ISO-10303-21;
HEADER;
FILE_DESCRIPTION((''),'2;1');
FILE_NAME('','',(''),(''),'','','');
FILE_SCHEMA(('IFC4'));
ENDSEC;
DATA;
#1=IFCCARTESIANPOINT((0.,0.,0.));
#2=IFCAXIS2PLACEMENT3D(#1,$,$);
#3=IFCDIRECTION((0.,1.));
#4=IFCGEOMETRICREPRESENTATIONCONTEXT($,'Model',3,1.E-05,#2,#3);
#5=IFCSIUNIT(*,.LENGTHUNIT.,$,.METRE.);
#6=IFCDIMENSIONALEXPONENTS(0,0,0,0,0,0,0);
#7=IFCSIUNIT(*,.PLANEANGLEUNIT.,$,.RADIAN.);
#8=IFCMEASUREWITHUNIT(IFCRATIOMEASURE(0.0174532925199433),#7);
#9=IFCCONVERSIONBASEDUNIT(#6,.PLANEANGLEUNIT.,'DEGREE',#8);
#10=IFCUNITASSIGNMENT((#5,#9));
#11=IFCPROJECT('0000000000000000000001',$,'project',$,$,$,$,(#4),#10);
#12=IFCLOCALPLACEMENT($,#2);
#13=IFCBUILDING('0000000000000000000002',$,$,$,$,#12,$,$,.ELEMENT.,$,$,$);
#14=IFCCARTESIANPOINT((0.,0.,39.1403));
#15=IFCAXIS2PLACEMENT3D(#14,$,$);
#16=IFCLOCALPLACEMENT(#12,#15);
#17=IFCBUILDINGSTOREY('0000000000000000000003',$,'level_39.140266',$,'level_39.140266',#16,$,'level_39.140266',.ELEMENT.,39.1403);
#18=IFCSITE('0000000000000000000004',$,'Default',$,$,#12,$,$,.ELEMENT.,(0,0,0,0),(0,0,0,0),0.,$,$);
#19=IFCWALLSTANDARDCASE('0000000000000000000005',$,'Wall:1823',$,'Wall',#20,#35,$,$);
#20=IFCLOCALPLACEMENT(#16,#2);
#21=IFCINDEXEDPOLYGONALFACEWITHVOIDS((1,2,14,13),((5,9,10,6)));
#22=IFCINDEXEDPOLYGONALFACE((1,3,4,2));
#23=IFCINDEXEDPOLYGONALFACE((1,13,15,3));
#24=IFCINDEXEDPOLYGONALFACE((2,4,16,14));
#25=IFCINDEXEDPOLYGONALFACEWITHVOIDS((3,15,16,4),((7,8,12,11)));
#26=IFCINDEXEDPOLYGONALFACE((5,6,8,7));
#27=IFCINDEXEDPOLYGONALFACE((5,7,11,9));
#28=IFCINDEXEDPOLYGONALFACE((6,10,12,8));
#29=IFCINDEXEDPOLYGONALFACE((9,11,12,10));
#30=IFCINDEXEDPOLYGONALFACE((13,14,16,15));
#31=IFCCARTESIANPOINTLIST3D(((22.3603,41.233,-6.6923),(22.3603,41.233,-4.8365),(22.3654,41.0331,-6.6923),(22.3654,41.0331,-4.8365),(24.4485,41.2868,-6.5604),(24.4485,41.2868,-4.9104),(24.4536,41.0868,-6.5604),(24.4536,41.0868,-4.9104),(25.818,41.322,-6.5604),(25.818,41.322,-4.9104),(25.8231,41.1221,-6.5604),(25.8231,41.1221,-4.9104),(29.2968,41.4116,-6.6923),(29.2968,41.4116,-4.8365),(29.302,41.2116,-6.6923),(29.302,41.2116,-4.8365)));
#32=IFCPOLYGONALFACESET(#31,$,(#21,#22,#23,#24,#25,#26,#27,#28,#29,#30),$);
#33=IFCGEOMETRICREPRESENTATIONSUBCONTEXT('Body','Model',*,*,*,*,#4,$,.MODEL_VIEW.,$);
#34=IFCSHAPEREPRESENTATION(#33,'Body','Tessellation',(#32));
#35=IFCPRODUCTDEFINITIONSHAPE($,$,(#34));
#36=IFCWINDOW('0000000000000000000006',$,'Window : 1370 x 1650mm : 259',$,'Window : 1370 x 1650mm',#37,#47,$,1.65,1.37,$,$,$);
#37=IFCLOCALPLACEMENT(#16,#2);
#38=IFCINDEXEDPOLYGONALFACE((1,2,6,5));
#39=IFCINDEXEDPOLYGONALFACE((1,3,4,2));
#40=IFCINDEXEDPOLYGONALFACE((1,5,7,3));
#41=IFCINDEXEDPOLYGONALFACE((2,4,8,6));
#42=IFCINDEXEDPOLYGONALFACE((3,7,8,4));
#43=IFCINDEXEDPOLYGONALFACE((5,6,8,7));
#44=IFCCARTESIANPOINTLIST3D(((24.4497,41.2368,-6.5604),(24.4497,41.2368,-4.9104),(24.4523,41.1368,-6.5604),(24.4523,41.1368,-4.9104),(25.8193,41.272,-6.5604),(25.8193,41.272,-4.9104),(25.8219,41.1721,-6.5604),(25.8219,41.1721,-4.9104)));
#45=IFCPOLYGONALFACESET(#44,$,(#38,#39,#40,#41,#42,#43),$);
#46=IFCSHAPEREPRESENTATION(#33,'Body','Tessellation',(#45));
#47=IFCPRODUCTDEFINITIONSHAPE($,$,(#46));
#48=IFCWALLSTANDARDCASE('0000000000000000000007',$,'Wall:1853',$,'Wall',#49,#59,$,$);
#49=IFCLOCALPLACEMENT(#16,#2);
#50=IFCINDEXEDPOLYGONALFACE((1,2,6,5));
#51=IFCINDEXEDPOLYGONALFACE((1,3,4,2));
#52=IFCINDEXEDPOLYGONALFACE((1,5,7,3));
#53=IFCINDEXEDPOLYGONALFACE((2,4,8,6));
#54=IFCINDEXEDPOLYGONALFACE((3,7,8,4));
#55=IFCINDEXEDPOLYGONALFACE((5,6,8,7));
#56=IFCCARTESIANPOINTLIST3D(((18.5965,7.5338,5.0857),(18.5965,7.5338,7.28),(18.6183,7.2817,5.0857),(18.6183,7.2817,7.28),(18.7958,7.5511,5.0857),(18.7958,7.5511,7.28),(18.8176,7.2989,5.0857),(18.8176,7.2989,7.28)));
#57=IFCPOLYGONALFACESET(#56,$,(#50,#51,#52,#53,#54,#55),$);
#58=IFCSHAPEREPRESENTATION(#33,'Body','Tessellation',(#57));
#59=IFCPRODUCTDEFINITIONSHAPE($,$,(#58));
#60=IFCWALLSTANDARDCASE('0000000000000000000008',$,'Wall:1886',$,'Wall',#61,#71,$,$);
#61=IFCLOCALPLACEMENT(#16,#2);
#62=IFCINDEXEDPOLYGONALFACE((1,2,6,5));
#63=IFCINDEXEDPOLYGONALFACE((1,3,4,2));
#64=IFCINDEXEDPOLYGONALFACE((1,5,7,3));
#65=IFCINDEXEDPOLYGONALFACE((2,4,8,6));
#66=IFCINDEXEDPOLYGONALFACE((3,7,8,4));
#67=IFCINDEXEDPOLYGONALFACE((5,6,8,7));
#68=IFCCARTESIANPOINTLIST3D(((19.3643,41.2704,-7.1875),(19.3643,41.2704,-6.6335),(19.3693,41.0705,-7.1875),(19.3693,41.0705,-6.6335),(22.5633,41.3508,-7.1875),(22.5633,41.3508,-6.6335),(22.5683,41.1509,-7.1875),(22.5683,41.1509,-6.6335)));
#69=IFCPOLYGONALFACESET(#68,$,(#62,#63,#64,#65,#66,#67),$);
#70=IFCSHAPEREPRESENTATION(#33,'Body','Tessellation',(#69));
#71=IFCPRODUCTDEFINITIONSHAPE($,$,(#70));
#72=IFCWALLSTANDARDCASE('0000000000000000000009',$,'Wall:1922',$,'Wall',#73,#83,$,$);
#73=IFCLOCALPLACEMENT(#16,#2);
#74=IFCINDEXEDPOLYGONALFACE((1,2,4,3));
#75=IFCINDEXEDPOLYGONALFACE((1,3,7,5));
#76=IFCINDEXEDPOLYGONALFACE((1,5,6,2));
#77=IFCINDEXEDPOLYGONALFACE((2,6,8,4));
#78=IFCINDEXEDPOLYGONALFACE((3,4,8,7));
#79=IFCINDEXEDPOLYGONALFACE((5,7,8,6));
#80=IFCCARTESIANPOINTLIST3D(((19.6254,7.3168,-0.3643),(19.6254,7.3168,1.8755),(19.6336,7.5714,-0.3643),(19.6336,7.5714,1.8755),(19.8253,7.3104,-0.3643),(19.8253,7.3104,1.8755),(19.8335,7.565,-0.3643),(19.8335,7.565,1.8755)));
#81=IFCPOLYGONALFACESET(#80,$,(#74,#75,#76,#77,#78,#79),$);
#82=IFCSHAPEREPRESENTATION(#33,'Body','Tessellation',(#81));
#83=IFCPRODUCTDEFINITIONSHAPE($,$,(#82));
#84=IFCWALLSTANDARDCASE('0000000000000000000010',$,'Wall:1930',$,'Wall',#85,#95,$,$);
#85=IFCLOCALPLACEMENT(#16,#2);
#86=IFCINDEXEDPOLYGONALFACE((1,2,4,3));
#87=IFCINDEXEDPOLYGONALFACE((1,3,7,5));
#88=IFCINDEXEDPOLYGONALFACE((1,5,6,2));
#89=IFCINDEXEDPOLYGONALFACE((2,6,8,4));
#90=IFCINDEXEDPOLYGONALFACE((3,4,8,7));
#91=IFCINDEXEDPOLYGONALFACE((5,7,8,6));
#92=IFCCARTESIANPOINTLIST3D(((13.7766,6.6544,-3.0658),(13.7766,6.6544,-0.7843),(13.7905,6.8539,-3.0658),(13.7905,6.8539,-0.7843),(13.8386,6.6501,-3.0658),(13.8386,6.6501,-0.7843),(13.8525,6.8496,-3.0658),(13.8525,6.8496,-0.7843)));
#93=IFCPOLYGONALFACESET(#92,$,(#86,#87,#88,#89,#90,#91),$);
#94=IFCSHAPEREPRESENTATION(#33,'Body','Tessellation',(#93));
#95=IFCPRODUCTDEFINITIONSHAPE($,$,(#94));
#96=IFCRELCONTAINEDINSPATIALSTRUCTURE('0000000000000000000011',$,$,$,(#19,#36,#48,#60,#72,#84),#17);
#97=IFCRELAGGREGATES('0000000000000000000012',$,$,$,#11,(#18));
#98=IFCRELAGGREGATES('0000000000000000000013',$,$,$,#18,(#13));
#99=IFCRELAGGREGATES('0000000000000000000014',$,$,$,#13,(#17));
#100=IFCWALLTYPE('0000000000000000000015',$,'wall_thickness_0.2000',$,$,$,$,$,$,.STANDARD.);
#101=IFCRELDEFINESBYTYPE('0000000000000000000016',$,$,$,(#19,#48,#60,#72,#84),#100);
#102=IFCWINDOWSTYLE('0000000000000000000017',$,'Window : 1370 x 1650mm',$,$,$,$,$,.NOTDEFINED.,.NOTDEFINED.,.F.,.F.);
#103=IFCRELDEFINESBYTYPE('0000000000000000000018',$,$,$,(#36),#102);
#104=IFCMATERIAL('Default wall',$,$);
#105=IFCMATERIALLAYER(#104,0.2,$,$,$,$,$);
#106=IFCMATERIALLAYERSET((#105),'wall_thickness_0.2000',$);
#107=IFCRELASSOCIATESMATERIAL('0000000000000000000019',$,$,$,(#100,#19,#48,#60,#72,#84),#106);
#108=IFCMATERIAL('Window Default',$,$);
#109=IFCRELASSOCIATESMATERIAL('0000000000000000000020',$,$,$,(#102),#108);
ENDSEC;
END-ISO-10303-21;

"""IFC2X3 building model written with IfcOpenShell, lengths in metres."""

from ifc_helpers import new_model, entity, si_unit, converted_unit, direction, frame, frame_2d, origin, origin_2d_with_axis, place, context, subcontext, project, spatial, polyline, rectangle, outline, extrude, source, transform, mapped, material, layer, layer_set, layer_usage, type_object, type_shapes, element, fill, save


model = new_model("IFC2X3")

# Units and contexts
model_context = context("Model", 3, precision=1e-05, world=origin(), true_north=direction((0.0, 1.0)))
body_context = subcontext(model_context, "Body", "Model", "MODEL_VIEW")
ifc_project = project(units=[si_unit("LENGTHUNIT", "METRE"), converted_unit("PLANEANGLEUNIT", "DEGREE", entity("IfcRatioMeasure", 0.0174532925199433), si_unit("PLANEANGLEUNIT", "RADIAN"), dimensions=[0, 0, 0, 0, 0, 0, 0])], contexts=[model_context])

# Site, building, storey
placement_1 = place(None, origin())
site = spatial("IfcSite", under=ifc_project, at=placement_1, Name="Default", CompositionType="ELEMENT", RefLatitude=(0, 0, 0, 0), RefLongitude=(0, 0, 0, 0), RefElevation=0.0)
building = spatial("IfcBuilding", under=site, at=placement_1, CompositionType="ELEMENT")
storey_placement = place(placement_1, frame((0.0, 0.0, 39.1403)))
storey = spatial("IfcBuildingStorey", under=building, at=storey_placement, Name="level_39.140266", ObjectType="level_39.140266", LongName="level_39.140266", CompositionType="ELEMENT", Elevation=39.1403)

# Shared definitions
ifc_material_1 = material(Name="Default wall")
ifc_layer = layer(ifc_material_1, 0.2)
ifc_layer_set = layer_set([ifc_layer], Name="wall_thickness_0.2000")
ifc_layer_usage = layer_usage(ifc_layer_set, "AXIS2", "POSITIVE", -0.1)
wall_type = type_object("IfcWallType", Name="wall_thickness_0.2000", PredefinedType="STANDARD", material=ifc_layer_set)

# Shared definitions
ifc_material_2 = material(Name="Window Default")

# Wall, opening, window
placement_2 = place(placement_1, frame((0.0, 0.0, 32.448)))
wall_1_placement = place(placement_2, frame((22.3628, 41.133, 0.0), z_axis=(0.0, 0.0, 1.0), x_axis=(0.999669, 0.025736, 0.0)))
wall_1 = element("IfcWallStandardCase", 1, at=wall_1_placement, inside=storey, type_object=wall_type, material=ifc_layer_usage, Name="Wall:1823", ObjectType="Wall", context=body_context, shape_type="SweptSolid", body=[
    extrude(outline(polyline([(6.9389, -0.1), (6.9389, 0.1), (0.0, 0.1), (0.0, -0.1), (6.9389, -0.1)])), origin(), (0.0, 0.0, 1.0), 1.8558),
])
opening_1_placement = place(wall_1_placement, frame((2.0889, -0.1, 0.132)))
opening_1 = element("IfcOpeningElement", 2, at=opening_1_placement, cuts=wall_1, ObjectType="Opening", context=body_context, shape_type="SweptSolid", body=[
    extrude(rectangle(XDim=1.37, YDim=1.65, at=frame_2d((0.825, 0.685), x_axis=(0.0, 1.0))), frame((0.0, 0.0, 0.0), z_axis=(0.0, 1.0, 0.0), x_axis=(0.0, 0.0, 1.0)), (0.0, 0.0, 1.0), 0.2),
])
window_style_1 = type_object("IfcWindowStyle", Name="Window : 1370 x 1650mm", ConstructionType="NOTDEFINED", OperationType="NOTDEFINED", ParameterTakesPrecedence=False, Sizeable=False, material=ifc_material_2)
shared_shape_1 = source(origin(), body_context, "Body", "SweptSolid", [
    extrude(rectangle(XDim=0.1, YDim=1.37, at=origin_2d_with_axis()), frame((0.685, 0.1, 0.0), z_axis=(0.0, 0.0, 1.0), x_axis=(0.0, 1.0, 0.0)), (0.0, 0.0, 1.0), 1.65),
])
type_shapes(window_style_1, [shared_shape_1])
window_1_placement = place(opening_1_placement, origin())
window_1 = element("IfcWindow", 3, at=window_1_placement, inside=storey, type_object=window_style_1, Name="Window : 1370 x 1650mm : 259", ObjectType="Window : 1370 x 1650mm", OverallHeight=1.65, OverallWidth=1.37, context=body_context, shape_type="MappedRepresentation", body=[
    mapped(shared_shape_1, transform((0.0, 0.0, 0.0), scale=1.0)),
])
fill(opening_1, window_1)

# Walls
placement_3 = place(placement_1, frame((0.0, 0.0, 44.226)))
wall_2_placement = place(placement_3, frame((18.718, 7.2903, 0.0), z_axis=(0.0, 0.0, 1.0), x_axis=(-0.086239, 0.996275, 0.0)))
element("IfcWallStandardCase", 4, at=wall_2_placement, inside=storey, type_object=wall_type, material=ifc_layer_usage, Name="Wall:1853", ObjectType="Wall", context=body_context, shape_type="SweptSolid", body=[
    extrude(outline(polyline([(0.2531, -0.1), (0.2531, 0.1), (0.0, 0.1), (0.0, -0.1), (0.2531, -0.1)])), origin(), (0.0, 0.0, 1.0), 2.1942),
])
placement_4 = place(placement_1, frame((0.0, 0.0, 31.9528)))
wall_3_placement = place(placement_4, frame((19.3668, 41.1704, 0.0), z_axis=(0.0, 0.0, 1.0), x_axis=(0.999684, 0.025127, 0.0)))
element("IfcWallStandardCase", 5, at=wall_3_placement, inside=storey, type_object=wall_type, material=ifc_layer_usage, Name="Wall:1886", ObjectType="Wall", context=body_context, shape_type="SweptSolid", body=[
    extrude(outline(polyline([(3.2, -0.1), (3.2, 0.1), (0.0, 0.1), (0.0, -0.1), (3.2, -0.1)])), origin(), (0.0, 0.0, 1.0), 0.554),
])
placement_5 = place(placement_1, frame((0.0, 0.0, 38.776)))
wall_4_placement = place(placement_5, frame((19.7253, 7.3136, 0.0), z_axis=(0.0, 0.0, 1.0), x_axis=(0.032279, 0.999479, 0.0)))
element("IfcWallStandardCase", 6, at=wall_4_placement, inside=storey, type_object=wall_type, material=ifc_layer_usage, Name="Wall:1922", ObjectType="Wall", context=body_context, shape_type="SweptSolid", body=[
    extrude(outline(polyline([(0.2547, -0.1), (0.2547, 0.1), (0.0, 0.1), (0.0, -0.1), (0.2547, -0.1)])), origin(), (0.0, 0.0, 1.0), 2.2397),
])
placement_6 = place(placement_1, frame((0.0, 0.0, 36.0745)))
wall_5_placement = place(placement_6, frame((13.8455, 6.7498, 0.0), z_axis=(0.0, 0.0, 1.0), x_axis=(-0.997582, 0.069504, 0.0)))
element("IfcWallStandardCase", 7, at=wall_5_placement, inside=storey, type_object=wall_type, material=ifc_layer_usage, Name="Wall:1930", ObjectType="Wall", context=body_context, shape_type="SweptSolid", body=[
    extrude(outline(polyline([(0.0621, -0.1), (0.0621, 0.1), (0.0, 0.1), (0.0, -0.1), (0.0621, -0.1)])), origin(), (0.0, 0.0, 1.0), 2.2815),
])

save(model, "model.ifc")
